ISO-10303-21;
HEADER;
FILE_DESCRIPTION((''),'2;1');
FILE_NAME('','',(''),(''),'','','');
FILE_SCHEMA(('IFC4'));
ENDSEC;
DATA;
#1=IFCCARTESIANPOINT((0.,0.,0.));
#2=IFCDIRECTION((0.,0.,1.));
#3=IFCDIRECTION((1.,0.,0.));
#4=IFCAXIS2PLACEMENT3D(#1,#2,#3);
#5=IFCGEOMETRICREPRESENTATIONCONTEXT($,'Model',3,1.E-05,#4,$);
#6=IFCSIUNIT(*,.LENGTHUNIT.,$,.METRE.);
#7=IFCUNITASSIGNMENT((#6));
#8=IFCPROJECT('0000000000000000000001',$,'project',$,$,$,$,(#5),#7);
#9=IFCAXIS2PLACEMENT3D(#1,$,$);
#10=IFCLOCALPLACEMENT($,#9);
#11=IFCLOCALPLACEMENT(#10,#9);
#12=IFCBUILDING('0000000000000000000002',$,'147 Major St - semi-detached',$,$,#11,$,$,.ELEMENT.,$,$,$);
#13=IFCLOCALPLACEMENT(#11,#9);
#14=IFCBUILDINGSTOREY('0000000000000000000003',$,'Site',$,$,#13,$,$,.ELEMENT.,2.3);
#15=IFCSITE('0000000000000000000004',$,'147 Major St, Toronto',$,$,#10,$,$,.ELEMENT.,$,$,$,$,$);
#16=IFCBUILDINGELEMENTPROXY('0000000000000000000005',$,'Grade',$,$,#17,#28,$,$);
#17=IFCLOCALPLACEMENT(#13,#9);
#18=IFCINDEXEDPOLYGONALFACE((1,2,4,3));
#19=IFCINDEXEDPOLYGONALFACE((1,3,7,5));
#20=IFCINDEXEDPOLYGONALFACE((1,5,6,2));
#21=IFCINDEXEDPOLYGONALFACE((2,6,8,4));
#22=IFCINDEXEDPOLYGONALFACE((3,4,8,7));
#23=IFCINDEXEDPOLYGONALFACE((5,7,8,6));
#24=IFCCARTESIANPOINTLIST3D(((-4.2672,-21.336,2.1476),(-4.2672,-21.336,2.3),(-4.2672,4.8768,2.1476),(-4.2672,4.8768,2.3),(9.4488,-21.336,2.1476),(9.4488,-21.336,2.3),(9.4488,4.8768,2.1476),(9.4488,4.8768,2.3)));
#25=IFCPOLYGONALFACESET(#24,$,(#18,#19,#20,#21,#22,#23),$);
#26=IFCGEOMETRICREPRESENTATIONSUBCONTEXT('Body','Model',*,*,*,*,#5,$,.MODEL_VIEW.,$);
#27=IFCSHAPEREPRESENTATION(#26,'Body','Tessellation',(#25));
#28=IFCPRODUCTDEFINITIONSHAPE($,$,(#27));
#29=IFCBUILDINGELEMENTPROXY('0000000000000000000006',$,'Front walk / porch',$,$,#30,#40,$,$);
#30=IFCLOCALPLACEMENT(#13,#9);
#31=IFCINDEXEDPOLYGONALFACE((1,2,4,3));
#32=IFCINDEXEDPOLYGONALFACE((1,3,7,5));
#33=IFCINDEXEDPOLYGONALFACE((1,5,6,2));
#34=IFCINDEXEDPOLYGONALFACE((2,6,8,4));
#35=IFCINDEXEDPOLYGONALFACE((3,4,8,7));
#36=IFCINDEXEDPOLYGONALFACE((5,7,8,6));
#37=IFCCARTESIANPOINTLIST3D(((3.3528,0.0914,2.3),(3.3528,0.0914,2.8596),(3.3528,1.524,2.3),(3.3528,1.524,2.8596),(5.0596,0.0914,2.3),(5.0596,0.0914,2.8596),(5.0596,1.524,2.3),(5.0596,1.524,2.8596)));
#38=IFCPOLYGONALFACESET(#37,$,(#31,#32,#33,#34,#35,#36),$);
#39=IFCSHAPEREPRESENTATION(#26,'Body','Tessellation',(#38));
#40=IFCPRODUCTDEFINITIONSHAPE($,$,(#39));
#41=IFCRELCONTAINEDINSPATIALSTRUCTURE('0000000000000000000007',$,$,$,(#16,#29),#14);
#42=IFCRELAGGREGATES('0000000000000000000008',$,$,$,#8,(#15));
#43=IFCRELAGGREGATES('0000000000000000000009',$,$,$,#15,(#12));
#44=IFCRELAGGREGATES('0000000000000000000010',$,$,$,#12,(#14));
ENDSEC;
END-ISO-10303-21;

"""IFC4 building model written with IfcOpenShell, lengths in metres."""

from ifc_helpers import new_model, si_unit, frame, origin, origin_with_axes, place, context, subcontext, project, spatial, rectangle, extrude, element, save


model = new_model("IFC4")

# Units and contexts
model_context = context("Model", 3, precision=1e-05, world=origin_with_axes())
body_context = subcontext(model_context, "Body", "Model", "MODEL_VIEW")
ifc_project = project(units=[si_unit("LENGTHUNIT", "METRE")], contexts=[model_context])

# Site, building, storey
site_placement = place(None, origin())
site = spatial("IfcSite", under=ifc_project, at=site_placement, Name="147 Major St, Toronto", CompositionType="ELEMENT")
building_placement = place(site_placement, origin())
building = spatial("IfcBuilding", under=site, at=building_placement, Name="147 Major St - semi-detached", CompositionType="ELEMENT")
storey_placement = place(building_placement, origin())
storey = spatial("IfcBuildingStorey", under=building, at=storey_placement, Name="Site", CompositionType="ELEMENT", Elevation=2.3)

# Building element proxies
proxy_1_placement = place(storey_placement, frame((2.5908, -8.2296, 2.1476)))
element("IfcBuildingElementProxy", 1, at=proxy_1_placement, inside=storey, Name="Grade", context=body_context, shape_type="SweptSolid", body=[
    extrude(rectangle(XDim=13.716, YDim=26.2128), origin_with_axes(), (0.0, 0.0, 1.0), 0.1524),
])
proxy_2_placement = place(storey_placement, frame((4.2062, 0.8077, 2.3)))
element("IfcBuildingElementProxy", 2, at=proxy_2_placement, inside=storey, Name="Front walk / porch", context=body_context, shape_type="SweptSolid", body=[
    extrude(rectangle(XDim=1.7069, YDim=1.4326), origin_with_axes(), (0.0, 0.0, 1.0), 0.5596),
])

save(model, "model.ifc")
